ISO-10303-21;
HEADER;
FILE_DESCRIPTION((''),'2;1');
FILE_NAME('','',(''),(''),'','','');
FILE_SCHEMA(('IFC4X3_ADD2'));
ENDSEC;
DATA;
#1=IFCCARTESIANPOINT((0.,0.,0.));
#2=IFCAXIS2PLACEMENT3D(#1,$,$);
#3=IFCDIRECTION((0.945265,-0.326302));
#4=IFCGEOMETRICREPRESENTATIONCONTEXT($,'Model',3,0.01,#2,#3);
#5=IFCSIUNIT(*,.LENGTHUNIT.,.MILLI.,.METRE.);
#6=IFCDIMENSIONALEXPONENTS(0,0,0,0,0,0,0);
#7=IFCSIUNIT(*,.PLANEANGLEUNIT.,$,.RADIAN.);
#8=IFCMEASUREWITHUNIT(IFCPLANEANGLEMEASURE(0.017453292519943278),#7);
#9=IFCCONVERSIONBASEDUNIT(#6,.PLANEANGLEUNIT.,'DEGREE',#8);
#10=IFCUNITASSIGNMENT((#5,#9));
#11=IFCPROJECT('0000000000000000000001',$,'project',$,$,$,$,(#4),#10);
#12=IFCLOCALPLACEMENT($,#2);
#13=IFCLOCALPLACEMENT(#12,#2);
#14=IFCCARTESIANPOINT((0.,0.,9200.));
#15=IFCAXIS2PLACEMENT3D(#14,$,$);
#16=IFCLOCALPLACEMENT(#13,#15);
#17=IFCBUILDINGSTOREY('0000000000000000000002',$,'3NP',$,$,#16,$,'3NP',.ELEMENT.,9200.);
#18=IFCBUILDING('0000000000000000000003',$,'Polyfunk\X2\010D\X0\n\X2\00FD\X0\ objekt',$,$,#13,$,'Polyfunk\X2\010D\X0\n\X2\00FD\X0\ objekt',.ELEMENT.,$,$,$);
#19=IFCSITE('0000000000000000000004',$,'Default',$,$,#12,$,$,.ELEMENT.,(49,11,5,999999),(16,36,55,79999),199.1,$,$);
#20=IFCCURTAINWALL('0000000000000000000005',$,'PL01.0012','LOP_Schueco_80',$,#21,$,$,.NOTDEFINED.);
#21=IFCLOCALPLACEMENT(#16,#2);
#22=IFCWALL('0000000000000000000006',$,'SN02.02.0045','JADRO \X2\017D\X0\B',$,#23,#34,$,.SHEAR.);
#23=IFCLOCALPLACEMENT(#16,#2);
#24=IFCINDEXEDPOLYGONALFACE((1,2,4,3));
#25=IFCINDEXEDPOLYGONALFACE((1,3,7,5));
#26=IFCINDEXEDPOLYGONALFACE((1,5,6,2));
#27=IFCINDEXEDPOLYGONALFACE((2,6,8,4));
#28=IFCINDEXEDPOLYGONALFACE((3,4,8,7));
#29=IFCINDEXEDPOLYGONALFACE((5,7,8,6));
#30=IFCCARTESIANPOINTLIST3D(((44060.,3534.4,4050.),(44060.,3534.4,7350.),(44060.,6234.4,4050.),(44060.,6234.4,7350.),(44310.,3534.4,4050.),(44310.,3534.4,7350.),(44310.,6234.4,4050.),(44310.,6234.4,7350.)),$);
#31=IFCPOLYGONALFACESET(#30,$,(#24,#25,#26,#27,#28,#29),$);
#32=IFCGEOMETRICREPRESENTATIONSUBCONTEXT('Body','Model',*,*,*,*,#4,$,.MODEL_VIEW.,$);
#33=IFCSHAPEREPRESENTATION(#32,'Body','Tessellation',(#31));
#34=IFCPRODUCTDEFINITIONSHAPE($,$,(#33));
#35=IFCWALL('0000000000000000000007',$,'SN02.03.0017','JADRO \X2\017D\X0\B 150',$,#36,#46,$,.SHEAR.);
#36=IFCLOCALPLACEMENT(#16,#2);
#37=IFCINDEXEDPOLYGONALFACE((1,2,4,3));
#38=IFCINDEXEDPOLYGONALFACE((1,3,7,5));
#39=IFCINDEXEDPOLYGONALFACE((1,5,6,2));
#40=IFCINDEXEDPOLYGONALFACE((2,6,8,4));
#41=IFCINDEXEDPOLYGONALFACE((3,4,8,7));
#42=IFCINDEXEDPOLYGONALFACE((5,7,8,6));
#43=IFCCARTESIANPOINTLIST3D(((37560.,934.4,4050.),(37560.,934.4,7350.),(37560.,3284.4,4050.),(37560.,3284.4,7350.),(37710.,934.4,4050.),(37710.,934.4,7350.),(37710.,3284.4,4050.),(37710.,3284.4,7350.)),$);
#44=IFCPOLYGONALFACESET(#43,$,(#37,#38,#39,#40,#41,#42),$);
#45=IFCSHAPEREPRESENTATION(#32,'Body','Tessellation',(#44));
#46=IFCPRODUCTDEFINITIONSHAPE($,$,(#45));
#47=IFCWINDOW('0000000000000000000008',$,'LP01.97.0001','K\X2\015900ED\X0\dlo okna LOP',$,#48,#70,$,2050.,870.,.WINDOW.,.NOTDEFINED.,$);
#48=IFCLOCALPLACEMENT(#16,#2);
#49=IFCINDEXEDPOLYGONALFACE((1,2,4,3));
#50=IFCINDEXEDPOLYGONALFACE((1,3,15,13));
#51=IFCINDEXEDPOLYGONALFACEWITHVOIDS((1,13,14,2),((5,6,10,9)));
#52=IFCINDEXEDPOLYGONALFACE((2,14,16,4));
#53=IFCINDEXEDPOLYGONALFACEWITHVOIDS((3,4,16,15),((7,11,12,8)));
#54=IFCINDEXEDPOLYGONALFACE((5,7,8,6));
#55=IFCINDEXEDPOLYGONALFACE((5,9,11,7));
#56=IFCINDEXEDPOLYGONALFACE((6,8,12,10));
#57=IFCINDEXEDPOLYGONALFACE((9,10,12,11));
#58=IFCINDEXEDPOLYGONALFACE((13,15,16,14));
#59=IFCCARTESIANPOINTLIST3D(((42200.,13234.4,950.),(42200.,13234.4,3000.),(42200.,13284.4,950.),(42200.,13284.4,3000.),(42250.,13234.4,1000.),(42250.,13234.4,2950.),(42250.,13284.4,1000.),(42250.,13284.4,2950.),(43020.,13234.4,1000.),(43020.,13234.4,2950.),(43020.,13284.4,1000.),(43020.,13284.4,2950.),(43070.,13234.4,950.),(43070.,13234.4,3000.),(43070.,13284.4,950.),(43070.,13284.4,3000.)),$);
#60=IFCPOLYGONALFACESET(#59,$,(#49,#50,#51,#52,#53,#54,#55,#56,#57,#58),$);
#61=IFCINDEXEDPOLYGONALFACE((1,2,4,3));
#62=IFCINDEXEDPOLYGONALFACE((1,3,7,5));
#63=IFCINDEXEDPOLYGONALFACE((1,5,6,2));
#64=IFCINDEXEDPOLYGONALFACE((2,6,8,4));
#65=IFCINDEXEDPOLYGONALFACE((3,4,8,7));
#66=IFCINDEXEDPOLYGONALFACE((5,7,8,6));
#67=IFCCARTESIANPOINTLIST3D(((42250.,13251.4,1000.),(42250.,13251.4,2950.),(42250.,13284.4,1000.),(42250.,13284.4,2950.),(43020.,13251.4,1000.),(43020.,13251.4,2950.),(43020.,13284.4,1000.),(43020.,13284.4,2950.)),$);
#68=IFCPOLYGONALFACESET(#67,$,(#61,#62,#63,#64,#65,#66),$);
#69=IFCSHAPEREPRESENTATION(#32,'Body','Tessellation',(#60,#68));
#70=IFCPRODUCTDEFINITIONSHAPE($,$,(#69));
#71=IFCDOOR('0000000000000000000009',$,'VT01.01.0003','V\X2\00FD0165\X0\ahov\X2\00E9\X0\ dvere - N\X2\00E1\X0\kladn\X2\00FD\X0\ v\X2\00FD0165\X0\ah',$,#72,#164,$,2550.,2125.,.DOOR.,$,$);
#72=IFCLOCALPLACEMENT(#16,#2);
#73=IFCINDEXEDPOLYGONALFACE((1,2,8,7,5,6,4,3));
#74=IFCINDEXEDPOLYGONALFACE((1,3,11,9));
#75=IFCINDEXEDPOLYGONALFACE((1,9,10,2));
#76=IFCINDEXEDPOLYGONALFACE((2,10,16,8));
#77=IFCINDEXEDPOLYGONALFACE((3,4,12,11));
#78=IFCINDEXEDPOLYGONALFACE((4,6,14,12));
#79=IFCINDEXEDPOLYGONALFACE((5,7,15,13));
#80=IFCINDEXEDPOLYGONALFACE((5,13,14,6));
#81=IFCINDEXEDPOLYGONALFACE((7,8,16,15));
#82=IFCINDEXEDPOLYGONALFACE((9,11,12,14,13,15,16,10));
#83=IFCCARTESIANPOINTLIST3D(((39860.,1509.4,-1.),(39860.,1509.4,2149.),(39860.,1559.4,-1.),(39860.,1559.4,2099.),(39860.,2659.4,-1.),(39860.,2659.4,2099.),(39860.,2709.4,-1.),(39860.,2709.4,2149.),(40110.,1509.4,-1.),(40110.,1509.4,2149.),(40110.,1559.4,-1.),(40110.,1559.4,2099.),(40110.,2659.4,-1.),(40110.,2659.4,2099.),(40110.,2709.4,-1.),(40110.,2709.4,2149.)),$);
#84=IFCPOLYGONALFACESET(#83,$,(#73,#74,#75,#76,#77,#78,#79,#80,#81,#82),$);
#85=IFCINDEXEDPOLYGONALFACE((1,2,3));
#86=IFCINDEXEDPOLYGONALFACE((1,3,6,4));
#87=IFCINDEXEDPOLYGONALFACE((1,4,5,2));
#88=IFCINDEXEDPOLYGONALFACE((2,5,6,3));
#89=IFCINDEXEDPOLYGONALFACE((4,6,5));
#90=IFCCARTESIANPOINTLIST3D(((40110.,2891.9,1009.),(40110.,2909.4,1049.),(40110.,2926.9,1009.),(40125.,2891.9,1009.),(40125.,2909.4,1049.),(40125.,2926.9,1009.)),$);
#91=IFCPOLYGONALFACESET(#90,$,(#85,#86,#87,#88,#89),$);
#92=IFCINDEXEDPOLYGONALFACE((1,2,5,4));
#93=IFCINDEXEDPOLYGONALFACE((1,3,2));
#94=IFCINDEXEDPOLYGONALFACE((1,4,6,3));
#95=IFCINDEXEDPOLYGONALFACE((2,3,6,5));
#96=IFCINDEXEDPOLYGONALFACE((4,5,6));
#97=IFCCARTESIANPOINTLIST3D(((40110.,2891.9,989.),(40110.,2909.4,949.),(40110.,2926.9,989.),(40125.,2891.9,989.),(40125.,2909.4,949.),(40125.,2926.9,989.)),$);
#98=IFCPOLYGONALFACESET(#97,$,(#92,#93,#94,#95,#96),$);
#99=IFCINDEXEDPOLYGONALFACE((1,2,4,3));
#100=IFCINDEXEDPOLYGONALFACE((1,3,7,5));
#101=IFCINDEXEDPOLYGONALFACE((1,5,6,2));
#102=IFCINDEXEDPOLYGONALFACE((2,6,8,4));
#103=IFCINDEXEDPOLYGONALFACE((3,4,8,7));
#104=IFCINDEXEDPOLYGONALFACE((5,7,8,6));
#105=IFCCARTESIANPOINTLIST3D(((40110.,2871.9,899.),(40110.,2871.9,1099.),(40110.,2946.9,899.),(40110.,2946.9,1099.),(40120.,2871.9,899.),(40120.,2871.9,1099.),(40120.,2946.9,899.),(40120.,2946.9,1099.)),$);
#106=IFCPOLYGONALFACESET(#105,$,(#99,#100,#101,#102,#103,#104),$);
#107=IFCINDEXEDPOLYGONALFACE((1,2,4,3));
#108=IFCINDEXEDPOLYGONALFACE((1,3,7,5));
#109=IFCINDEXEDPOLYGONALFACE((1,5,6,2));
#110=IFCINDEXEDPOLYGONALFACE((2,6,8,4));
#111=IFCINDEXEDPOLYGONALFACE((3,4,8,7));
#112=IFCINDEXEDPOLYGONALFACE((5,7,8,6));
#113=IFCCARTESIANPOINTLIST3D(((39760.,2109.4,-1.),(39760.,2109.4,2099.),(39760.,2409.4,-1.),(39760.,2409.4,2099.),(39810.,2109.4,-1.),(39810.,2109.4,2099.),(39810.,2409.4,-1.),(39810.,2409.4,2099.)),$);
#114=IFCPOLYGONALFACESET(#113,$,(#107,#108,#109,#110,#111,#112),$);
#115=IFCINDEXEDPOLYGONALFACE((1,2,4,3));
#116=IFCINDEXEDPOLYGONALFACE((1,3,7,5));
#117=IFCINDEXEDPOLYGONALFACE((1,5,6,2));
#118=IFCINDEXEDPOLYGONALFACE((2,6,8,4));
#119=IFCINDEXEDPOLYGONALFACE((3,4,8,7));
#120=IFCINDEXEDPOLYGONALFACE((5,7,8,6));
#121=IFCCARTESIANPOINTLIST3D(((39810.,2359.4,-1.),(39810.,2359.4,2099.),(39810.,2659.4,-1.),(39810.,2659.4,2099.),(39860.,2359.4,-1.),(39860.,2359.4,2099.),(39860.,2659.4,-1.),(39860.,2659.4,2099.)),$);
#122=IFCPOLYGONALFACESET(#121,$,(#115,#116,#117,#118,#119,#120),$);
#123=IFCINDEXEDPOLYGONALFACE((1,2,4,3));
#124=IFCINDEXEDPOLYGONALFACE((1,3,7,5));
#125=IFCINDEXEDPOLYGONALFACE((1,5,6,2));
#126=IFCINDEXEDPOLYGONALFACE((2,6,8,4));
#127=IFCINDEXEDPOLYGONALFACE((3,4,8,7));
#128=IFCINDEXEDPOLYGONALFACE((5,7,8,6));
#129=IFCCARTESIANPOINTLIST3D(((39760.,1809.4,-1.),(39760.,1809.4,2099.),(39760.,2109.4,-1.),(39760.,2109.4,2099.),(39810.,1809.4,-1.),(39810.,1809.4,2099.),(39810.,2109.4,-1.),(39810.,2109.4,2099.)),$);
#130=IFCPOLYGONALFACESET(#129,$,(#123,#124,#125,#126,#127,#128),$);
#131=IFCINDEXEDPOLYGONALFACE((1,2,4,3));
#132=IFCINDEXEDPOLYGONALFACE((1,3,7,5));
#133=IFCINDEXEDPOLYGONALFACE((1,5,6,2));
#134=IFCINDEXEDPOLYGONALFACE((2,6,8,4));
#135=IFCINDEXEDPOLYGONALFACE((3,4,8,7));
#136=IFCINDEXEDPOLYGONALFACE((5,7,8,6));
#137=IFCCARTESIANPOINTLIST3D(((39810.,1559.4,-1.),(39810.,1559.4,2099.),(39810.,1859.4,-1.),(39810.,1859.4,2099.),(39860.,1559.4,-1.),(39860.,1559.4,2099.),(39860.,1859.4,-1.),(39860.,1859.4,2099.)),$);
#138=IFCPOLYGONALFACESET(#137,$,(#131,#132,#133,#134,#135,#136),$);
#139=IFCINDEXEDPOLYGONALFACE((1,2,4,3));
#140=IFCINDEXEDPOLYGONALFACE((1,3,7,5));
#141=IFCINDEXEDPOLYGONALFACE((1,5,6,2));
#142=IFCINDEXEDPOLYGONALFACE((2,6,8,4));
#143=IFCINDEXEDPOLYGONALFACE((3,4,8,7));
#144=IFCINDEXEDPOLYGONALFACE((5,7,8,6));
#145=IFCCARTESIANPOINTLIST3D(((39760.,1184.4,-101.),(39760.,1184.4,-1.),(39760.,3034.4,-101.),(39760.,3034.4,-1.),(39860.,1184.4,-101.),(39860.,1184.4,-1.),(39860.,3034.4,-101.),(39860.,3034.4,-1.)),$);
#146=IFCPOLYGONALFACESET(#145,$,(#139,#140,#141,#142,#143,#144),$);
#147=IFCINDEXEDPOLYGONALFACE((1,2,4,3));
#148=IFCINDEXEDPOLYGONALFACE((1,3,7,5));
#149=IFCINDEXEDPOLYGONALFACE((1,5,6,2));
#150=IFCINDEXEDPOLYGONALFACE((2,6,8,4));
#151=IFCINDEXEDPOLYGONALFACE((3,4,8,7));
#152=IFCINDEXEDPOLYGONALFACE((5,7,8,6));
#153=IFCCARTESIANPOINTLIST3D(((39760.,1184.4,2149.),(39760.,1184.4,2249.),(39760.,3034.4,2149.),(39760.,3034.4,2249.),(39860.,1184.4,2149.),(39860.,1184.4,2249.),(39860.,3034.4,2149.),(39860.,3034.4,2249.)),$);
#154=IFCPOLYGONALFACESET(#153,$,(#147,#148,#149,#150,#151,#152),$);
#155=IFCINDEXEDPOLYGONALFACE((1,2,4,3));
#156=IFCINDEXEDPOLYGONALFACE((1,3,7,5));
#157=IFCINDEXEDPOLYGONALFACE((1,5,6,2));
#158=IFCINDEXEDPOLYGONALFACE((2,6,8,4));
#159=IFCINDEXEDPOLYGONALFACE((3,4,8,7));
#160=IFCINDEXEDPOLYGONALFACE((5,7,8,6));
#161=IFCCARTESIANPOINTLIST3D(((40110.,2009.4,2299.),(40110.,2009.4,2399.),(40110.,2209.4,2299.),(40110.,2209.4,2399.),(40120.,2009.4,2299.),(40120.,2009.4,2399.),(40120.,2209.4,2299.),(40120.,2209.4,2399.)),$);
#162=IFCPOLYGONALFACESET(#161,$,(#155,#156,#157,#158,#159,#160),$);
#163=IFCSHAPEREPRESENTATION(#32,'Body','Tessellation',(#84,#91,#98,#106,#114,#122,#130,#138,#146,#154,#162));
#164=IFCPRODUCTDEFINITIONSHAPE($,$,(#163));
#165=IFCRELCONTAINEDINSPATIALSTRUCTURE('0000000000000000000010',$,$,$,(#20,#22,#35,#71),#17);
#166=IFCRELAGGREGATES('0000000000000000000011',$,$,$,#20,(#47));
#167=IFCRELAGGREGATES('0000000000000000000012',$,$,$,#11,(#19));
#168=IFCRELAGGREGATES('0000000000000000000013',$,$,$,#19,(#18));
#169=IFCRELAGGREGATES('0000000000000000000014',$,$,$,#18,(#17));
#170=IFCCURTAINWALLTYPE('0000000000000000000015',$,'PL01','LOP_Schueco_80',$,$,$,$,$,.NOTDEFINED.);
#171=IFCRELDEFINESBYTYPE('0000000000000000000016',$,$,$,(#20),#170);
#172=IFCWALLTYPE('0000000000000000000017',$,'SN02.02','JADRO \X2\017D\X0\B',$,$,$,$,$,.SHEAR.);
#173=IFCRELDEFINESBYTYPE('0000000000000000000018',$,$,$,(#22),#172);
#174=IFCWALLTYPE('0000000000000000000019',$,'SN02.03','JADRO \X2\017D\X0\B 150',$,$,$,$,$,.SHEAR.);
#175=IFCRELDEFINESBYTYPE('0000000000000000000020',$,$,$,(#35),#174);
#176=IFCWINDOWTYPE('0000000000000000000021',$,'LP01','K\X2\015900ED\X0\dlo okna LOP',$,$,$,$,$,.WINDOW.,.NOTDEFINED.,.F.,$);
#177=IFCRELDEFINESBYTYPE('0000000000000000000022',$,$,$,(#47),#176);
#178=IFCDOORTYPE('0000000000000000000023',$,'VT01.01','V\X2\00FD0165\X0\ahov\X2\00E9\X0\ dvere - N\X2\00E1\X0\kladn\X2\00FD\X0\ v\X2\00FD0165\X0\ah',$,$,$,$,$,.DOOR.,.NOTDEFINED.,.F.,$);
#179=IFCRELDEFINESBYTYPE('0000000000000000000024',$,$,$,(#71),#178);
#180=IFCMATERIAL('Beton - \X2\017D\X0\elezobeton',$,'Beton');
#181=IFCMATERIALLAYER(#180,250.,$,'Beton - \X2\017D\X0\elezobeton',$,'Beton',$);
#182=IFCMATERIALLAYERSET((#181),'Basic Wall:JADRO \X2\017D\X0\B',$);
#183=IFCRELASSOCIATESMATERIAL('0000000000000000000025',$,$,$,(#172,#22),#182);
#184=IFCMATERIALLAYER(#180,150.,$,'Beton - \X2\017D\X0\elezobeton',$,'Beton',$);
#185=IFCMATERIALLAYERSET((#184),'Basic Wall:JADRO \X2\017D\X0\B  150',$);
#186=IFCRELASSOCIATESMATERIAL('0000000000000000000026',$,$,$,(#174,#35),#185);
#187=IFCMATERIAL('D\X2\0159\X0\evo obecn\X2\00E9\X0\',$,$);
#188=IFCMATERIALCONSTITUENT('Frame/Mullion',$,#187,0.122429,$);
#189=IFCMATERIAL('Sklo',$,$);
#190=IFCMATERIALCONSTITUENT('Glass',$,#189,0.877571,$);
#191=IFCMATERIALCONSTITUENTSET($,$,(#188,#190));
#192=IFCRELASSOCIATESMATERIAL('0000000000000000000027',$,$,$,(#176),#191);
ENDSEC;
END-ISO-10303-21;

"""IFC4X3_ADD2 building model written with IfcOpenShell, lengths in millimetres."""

from ifc_helpers import new_model, entity, si_unit, converted_unit, direction, frame, frame_2d, origin, origin_2d_with_axis, place, context, subcontext, project, spatial, polyline, rectangle, outline, extrude, clip, bounded_halfspace, source, transform, mapped, material, layer, layer_set, constituent, constituent_set, type_object, type_shapes, element, aggregate, save


model = new_model("IFC4X3_ADD2")

# Units and contexts
model_context = context("Model", 3, precision=0.01, world=origin(), true_north=direction((0.945265, -0.326302)))
body_context = subcontext(model_context, "Body", "Model", "MODEL_VIEW")
ifc_project = project(units=[si_unit("LENGTHUNIT", "METRE", prefix="MILLI"), converted_unit("PLANEANGLEUNIT", "DEGREE", entity("IfcPlaneAngleMeasure", 0.017453292519943278), si_unit("PLANEANGLEUNIT", "RADIAN"), dimensions=[0, 0, 0, 0, 0, 0, 0])], contexts=[model_context])

# Site, building, storey
site_placement = place(None, origin())
site = spatial("IfcSite", under=ifc_project, at=site_placement, Name="Default", CompositionType="ELEMENT", RefLatitude=(49, 11, 5, 999999), RefLongitude=(16, 36, 55, 79999), RefElevation=199.1)
building_placement = place(site_placement, origin())
building = spatial("IfcBuilding", under=site, at=building_placement, Name="Polyfunkčný objekt", LongName="Polyfunkčný objekt", CompositionType="ELEMENT")
storey_placement = place(building_placement, frame((0.0, 0.0, 9200.0)))
storey = spatial("IfcBuildingStorey", under=building, at=storey_placement, Name="3NP", LongName="3NP", CompositionType="ELEMENT", Elevation=9200.0)

# Curtain wall
curtain_wall_type = type_object("IfcCurtainWallType", Name="PL01", Description="LOP_Schueco_80", PredefinedType="NOTDEFINED")
curtain_wall_placement = place(storey_placement, frame((0.0, 0.0, -9200.0)))
curtain_wall = element("IfcCurtainWall", 1, at=curtain_wall_placement, inside=storey, type_object=curtain_wall_type, Name="PL01.0012", Description="LOP_Schueco_80", PredefinedType="NOTDEFINED")
ifc_material_1 = material(Name="Sklo")

# Walls
ifc_material_2 = material(Name="Beton - Železobeton", Category="Beton")
ifc_layer_1 = layer(ifc_material_2, 250.0, Name="Beton - Železobeton", Category="Beton")
ifc_layer_set_1 = layer_set([ifc_layer_1], Name="Basic Wall:JADRO ŽB")
wall_type_1 = type_object("IfcWallType", Name="SN02.02", Description="JADRO ŽB", PredefinedType="SHEAR", material=ifc_layer_set_1)
wall_1_placement = place(storey_placement, frame((44185.0, 6234.4, 4050.0), z_axis=(0.0, 0.0, 1.0), x_axis=(0.0, -1.0, 0.0)))
element("IfcWall", 2, at=wall_1_placement, inside=storey, type_object=wall_type_1, material=ifc_layer_set_1, Name="SN02.02.0045", Description="JADRO ŽB", PredefinedType="SHEAR", context=body_context, shape_type="Clipping", body=[
    clip(clip(extrude(rectangle(XDim=2700.0, YDim=250.0, at=frame_2d((1350.0, 0.0), x_axis=(-1.0, 0.0))), origin(), (0.0, 0.0, 1.0), 3300.0), bounded_halfspace(frame((2700.0, -125.0, 0.0), z_axis=(0.0, 0.0, 1.0), x_axis=(0.0, -1.0, 0.0)), True, frame((2700.0, -125.0, 0.0)), polyline([(0.0, 0.0), (0.0, 250.0), (-2700.0, 250.0), (-2700.0, 0.0), (0.0, 0.0)]))), bounded_halfspace(frame((0.0, -125.0, 3300.0), z_axis=(0.0, 0.0, -1.0), x_axis=(1.0, 0.0, 0.0)), True, frame((0.0, -125.0, 3300.0)), polyline([(0.0, 0.0), (2700.0, 0.0), (2700.0, 250.0), (0.0, 250.0), (0.0, 0.0)]))),
])
ifc_layer_2 = layer(ifc_material_2, 150.0, Name="Beton - Železobeton", Category="Beton")
ifc_layer_set_2 = layer_set([ifc_layer_2], Name="Basic Wall:JADRO ŽB  150")
wall_type_2 = type_object("IfcWallType", Name="SN02.03", Description="JADRO ŽB 150", PredefinedType="SHEAR", material=ifc_layer_set_2)
wall_2_placement = place(storey_placement, frame((37635.0, 3284.4, 4050.0), z_axis=(0.0, 0.0, 1.0), x_axis=(0.0, -1.0, 0.0)))
element("IfcWall", 3, at=wall_2_placement, inside=storey, type_object=wall_type_2, material=ifc_layer_set_2, Name="SN02.03.0017", Description="JADRO ŽB 150", PredefinedType="SHEAR", context=body_context, shape_type="SweptSolid", body=[
    extrude(rectangle(XDim=2350.0, YDim=150.0, at=frame_2d((1175.0, 0.0), x_axis=(-1.0, 0.0))), origin(), (0.0, 0.0, 1.0), 3300.0),
])

# Window
ifc_material_3 = material(Name="Dřevo obecné")
ifc_constituent_1 = constituent(ifc_material_3, Name="Frame/Mullion", fraction=0.122429)
ifc_constituent_2 = constituent(ifc_material_1, Name="Glass", fraction=0.877571)
ifc_constituent_set = constituent_set(constituents=[ifc_constituent_1, ifc_constituent_2])
window_type = type_object("IfcWindowType", Name="LP01", Description="Křídlo okna LOP", ParameterTakesPrecedence=False, PartitioningType="NOTDEFINED", PredefinedType="WINDOW", material=ifc_constituent_set)
shared_shape_1 = source(origin(), body_context, "Body", "SweptSolid", [
    extrude(outline(polyline([(-1025.0, -435.0), (1025.0, -435.0), (1025.0, 435.0), (-1025.0, 435.0), (-1025.0, -435.0)]), holes=[polyline([(-975.0, -385.0), (-975.0, 385.0), (975.0, 385.0), (975.0, -385.0), (-975.0, -385.0)])]), frame((0.0, 0.0, 1025.0), z_axis=(0.0, 1.0, 0.0), x_axis=(0.0, 0.0, -1.0)), (0.0, 0.0, 1.0), 50.0),
    extrude(rectangle(XDim=33.0, YDim=770.0, at=origin_2d_with_axis()), frame((0.0, 33.5, 50.0), z_axis=(0.0, 0.0, 1.0), x_axis=(0.0, -1.0, 0.0)), (0.0, 0.0, 1.0), 1950.0),
])
type_shapes(window_type, [shared_shape_1])
window_placement = place(curtain_wall_placement, frame((42635.0, 13234.4, 10150.0)))
window = element("IfcWindow", 4, at=window_placement, type_object=window_type, Name="LP01.97.0001", Description="Křídlo okna LOP", OverallHeight=2050.0, OverallWidth=870.0, PartitioningType="NOTDEFINED", PredefinedType="WINDOW", context=body_context, shape_type="MappedRepresentation", body=[
    mapped(shared_shape_1, transform((0.0, 0.0, 0.0), scale=1.0)),
])
aggregate(curtain_wall, [window])

# Door
door_type = type_object("IfcDoorType", Name="VT01.01", Description="Výťahové dvere - Nákladný výťah", OperationType="NOTDEFINED", ParameterTakesPrecedence=False, PredefinedType="DOOR")
shared_shape_2 = source(origin(), body_context, "Body", "SweptSolid", [
    extrude(outline(polyline([(-1087.5, -600.0), (1062.5, -600.0), (1062.5, -550.0), (-1037.5, -550.0), (-1037.5, 550.0), (1062.5, 550.0), (1062.5, 600.0), (-1087.5, 600.0), (-1087.5, -600.0)])), frame((600.0, 0.0, 1062.5), z_axis=(0.0, 1.0, 0.0), x_axis=(0.0, 0.0, -1.0)), (0.0, 0.0, 1.0), 250.0),
    extrude(outline(polyline([(-24.4, -10.7), (19.2, -10.7), (5.2, 21.4), (-24.4, -10.7)])), frame((1400.0, -15.0, 1023.3), z_axis=(0.0, 1.0, 0.0), x_axis=(0.400819, 0.0, -0.916157)), (0.0, 0.0, 1.0), 15.0),
    extrude(outline(polyline([(-24.4, -10.7), (19.2, -10.7), (5.2, 21.4), (-24.4, -10.7)])), frame((1400.0, -15.0, 976.7), z_axis=(0.0, 1.0, 0.0), x_axis=(-0.400819, 0.0, 0.916157)), (0.0, 0.0, 1.0), 15.0),
    extrude(rectangle(XDim=10.0, YDim=75.0, at=frame_2d((0.0, 0.0), x_axis=(1.0, 0.0))), frame((1400.0, -5.0, 900.0), z_axis=(0.0, 0.0, 1.0), x_axis=(0.0, 1.0, 0.0)), (0.0, 0.0, 1.0), 200.0),
    extrude(rectangle(XDim=50.0, YDim=300.0, at=origin_2d_with_axis()), frame((750.0, 325.0, 0.0), z_axis=(0.0, 0.0, 1.0), x_axis=(0.0, -1.0, 0.0)), (0.0, 0.0, 1.0), 2100.0),
    extrude(rectangle(XDim=50.0, YDim=300.0, at=frame_2d((0.0, 0.0), x_axis=(1.0, 0.0))), frame((1000.0, 275.0, 0.0), z_axis=(0.0, 0.0, 1.0), x_axis=(0.0, -1.0, 0.0)), (0.0, 0.0, 1.0), 2100.0),
    extrude(rectangle(XDim=300.0, YDim=50.0, at=frame_2d((0.0, 0.0), x_axis=(1.0, 0.0))), frame((450.0, 325.0, 0.0), z_axis=(0.0, 0.0, 1.0), x_axis=(-1.0, 0.0, 0.0)), (0.0, 0.0, 1.0), 2100.0),
    extrude(rectangle(XDim=300.0, YDim=50.0, at=frame_2d((0.0, 0.0), x_axis=(1.0, 0.0))), frame((200.0, 275.0, 0.0), z_axis=(0.0, 0.0, 1.0), x_axis=(-1.0, 0.0, 0.0)), (0.0, 0.0, 1.0), 2100.0),
    extrude(rectangle(XDim=1850.0, YDim=100.0, at=frame_2d((0.0, 0.0), x_axis=(1.0, 0.0))), frame((600.0, 300.0, -100.0), z_axis=(0.0, 0.0, 1.0), x_axis=(-1.0, 0.0, 0.0)), (0.0, 0.0, 1.0), 100.0),
    extrude(rectangle(XDim=1850.0, YDim=100.0, at=frame_2d((0.0, 0.0), x_axis=(1.0, 0.0))), frame((600.0, 300.0, 2150.0), z_axis=(0.0, 0.0, 1.0), x_axis=(-1.0, 0.0, 0.0)), (0.0, 0.0, 1.0), 100.0),
    extrude(rectangle(XDim=10.0, YDim=200.0, at=frame_2d((0.0, 0.0), x_axis=(1.0, 0.0))), frame((600.0, -5.0, 2300.0), z_axis=(0.0, 0.0, 1.0), x_axis=(0.0, 1.0, 0.0)), (0.0, 0.0, 1.0), 100.0),
])
type_shapes(door_type, [shared_shape_2])
door_placement = place(storey_placement, frame((40110.0, 1509.4, -1.0), z_axis=(0.0, 0.0, 1.0), x_axis=(0.0, 1.0, 0.0)))
element("IfcDoor", 5, at=door_placement, inside=storey, type_object=door_type, Name="VT01.01.0003", Description="Výťahové dvere - Nákladný výťah", OverallHeight=2550.0, OverallWidth=2125.0, PredefinedType="DOOR", context=body_context, shape_type="MappedRepresentation", body=[
    mapped(shared_shape_2, transform((0.0, 0.0, 0.0), scale=1.0)),
])

save(model, "model.ifc")
